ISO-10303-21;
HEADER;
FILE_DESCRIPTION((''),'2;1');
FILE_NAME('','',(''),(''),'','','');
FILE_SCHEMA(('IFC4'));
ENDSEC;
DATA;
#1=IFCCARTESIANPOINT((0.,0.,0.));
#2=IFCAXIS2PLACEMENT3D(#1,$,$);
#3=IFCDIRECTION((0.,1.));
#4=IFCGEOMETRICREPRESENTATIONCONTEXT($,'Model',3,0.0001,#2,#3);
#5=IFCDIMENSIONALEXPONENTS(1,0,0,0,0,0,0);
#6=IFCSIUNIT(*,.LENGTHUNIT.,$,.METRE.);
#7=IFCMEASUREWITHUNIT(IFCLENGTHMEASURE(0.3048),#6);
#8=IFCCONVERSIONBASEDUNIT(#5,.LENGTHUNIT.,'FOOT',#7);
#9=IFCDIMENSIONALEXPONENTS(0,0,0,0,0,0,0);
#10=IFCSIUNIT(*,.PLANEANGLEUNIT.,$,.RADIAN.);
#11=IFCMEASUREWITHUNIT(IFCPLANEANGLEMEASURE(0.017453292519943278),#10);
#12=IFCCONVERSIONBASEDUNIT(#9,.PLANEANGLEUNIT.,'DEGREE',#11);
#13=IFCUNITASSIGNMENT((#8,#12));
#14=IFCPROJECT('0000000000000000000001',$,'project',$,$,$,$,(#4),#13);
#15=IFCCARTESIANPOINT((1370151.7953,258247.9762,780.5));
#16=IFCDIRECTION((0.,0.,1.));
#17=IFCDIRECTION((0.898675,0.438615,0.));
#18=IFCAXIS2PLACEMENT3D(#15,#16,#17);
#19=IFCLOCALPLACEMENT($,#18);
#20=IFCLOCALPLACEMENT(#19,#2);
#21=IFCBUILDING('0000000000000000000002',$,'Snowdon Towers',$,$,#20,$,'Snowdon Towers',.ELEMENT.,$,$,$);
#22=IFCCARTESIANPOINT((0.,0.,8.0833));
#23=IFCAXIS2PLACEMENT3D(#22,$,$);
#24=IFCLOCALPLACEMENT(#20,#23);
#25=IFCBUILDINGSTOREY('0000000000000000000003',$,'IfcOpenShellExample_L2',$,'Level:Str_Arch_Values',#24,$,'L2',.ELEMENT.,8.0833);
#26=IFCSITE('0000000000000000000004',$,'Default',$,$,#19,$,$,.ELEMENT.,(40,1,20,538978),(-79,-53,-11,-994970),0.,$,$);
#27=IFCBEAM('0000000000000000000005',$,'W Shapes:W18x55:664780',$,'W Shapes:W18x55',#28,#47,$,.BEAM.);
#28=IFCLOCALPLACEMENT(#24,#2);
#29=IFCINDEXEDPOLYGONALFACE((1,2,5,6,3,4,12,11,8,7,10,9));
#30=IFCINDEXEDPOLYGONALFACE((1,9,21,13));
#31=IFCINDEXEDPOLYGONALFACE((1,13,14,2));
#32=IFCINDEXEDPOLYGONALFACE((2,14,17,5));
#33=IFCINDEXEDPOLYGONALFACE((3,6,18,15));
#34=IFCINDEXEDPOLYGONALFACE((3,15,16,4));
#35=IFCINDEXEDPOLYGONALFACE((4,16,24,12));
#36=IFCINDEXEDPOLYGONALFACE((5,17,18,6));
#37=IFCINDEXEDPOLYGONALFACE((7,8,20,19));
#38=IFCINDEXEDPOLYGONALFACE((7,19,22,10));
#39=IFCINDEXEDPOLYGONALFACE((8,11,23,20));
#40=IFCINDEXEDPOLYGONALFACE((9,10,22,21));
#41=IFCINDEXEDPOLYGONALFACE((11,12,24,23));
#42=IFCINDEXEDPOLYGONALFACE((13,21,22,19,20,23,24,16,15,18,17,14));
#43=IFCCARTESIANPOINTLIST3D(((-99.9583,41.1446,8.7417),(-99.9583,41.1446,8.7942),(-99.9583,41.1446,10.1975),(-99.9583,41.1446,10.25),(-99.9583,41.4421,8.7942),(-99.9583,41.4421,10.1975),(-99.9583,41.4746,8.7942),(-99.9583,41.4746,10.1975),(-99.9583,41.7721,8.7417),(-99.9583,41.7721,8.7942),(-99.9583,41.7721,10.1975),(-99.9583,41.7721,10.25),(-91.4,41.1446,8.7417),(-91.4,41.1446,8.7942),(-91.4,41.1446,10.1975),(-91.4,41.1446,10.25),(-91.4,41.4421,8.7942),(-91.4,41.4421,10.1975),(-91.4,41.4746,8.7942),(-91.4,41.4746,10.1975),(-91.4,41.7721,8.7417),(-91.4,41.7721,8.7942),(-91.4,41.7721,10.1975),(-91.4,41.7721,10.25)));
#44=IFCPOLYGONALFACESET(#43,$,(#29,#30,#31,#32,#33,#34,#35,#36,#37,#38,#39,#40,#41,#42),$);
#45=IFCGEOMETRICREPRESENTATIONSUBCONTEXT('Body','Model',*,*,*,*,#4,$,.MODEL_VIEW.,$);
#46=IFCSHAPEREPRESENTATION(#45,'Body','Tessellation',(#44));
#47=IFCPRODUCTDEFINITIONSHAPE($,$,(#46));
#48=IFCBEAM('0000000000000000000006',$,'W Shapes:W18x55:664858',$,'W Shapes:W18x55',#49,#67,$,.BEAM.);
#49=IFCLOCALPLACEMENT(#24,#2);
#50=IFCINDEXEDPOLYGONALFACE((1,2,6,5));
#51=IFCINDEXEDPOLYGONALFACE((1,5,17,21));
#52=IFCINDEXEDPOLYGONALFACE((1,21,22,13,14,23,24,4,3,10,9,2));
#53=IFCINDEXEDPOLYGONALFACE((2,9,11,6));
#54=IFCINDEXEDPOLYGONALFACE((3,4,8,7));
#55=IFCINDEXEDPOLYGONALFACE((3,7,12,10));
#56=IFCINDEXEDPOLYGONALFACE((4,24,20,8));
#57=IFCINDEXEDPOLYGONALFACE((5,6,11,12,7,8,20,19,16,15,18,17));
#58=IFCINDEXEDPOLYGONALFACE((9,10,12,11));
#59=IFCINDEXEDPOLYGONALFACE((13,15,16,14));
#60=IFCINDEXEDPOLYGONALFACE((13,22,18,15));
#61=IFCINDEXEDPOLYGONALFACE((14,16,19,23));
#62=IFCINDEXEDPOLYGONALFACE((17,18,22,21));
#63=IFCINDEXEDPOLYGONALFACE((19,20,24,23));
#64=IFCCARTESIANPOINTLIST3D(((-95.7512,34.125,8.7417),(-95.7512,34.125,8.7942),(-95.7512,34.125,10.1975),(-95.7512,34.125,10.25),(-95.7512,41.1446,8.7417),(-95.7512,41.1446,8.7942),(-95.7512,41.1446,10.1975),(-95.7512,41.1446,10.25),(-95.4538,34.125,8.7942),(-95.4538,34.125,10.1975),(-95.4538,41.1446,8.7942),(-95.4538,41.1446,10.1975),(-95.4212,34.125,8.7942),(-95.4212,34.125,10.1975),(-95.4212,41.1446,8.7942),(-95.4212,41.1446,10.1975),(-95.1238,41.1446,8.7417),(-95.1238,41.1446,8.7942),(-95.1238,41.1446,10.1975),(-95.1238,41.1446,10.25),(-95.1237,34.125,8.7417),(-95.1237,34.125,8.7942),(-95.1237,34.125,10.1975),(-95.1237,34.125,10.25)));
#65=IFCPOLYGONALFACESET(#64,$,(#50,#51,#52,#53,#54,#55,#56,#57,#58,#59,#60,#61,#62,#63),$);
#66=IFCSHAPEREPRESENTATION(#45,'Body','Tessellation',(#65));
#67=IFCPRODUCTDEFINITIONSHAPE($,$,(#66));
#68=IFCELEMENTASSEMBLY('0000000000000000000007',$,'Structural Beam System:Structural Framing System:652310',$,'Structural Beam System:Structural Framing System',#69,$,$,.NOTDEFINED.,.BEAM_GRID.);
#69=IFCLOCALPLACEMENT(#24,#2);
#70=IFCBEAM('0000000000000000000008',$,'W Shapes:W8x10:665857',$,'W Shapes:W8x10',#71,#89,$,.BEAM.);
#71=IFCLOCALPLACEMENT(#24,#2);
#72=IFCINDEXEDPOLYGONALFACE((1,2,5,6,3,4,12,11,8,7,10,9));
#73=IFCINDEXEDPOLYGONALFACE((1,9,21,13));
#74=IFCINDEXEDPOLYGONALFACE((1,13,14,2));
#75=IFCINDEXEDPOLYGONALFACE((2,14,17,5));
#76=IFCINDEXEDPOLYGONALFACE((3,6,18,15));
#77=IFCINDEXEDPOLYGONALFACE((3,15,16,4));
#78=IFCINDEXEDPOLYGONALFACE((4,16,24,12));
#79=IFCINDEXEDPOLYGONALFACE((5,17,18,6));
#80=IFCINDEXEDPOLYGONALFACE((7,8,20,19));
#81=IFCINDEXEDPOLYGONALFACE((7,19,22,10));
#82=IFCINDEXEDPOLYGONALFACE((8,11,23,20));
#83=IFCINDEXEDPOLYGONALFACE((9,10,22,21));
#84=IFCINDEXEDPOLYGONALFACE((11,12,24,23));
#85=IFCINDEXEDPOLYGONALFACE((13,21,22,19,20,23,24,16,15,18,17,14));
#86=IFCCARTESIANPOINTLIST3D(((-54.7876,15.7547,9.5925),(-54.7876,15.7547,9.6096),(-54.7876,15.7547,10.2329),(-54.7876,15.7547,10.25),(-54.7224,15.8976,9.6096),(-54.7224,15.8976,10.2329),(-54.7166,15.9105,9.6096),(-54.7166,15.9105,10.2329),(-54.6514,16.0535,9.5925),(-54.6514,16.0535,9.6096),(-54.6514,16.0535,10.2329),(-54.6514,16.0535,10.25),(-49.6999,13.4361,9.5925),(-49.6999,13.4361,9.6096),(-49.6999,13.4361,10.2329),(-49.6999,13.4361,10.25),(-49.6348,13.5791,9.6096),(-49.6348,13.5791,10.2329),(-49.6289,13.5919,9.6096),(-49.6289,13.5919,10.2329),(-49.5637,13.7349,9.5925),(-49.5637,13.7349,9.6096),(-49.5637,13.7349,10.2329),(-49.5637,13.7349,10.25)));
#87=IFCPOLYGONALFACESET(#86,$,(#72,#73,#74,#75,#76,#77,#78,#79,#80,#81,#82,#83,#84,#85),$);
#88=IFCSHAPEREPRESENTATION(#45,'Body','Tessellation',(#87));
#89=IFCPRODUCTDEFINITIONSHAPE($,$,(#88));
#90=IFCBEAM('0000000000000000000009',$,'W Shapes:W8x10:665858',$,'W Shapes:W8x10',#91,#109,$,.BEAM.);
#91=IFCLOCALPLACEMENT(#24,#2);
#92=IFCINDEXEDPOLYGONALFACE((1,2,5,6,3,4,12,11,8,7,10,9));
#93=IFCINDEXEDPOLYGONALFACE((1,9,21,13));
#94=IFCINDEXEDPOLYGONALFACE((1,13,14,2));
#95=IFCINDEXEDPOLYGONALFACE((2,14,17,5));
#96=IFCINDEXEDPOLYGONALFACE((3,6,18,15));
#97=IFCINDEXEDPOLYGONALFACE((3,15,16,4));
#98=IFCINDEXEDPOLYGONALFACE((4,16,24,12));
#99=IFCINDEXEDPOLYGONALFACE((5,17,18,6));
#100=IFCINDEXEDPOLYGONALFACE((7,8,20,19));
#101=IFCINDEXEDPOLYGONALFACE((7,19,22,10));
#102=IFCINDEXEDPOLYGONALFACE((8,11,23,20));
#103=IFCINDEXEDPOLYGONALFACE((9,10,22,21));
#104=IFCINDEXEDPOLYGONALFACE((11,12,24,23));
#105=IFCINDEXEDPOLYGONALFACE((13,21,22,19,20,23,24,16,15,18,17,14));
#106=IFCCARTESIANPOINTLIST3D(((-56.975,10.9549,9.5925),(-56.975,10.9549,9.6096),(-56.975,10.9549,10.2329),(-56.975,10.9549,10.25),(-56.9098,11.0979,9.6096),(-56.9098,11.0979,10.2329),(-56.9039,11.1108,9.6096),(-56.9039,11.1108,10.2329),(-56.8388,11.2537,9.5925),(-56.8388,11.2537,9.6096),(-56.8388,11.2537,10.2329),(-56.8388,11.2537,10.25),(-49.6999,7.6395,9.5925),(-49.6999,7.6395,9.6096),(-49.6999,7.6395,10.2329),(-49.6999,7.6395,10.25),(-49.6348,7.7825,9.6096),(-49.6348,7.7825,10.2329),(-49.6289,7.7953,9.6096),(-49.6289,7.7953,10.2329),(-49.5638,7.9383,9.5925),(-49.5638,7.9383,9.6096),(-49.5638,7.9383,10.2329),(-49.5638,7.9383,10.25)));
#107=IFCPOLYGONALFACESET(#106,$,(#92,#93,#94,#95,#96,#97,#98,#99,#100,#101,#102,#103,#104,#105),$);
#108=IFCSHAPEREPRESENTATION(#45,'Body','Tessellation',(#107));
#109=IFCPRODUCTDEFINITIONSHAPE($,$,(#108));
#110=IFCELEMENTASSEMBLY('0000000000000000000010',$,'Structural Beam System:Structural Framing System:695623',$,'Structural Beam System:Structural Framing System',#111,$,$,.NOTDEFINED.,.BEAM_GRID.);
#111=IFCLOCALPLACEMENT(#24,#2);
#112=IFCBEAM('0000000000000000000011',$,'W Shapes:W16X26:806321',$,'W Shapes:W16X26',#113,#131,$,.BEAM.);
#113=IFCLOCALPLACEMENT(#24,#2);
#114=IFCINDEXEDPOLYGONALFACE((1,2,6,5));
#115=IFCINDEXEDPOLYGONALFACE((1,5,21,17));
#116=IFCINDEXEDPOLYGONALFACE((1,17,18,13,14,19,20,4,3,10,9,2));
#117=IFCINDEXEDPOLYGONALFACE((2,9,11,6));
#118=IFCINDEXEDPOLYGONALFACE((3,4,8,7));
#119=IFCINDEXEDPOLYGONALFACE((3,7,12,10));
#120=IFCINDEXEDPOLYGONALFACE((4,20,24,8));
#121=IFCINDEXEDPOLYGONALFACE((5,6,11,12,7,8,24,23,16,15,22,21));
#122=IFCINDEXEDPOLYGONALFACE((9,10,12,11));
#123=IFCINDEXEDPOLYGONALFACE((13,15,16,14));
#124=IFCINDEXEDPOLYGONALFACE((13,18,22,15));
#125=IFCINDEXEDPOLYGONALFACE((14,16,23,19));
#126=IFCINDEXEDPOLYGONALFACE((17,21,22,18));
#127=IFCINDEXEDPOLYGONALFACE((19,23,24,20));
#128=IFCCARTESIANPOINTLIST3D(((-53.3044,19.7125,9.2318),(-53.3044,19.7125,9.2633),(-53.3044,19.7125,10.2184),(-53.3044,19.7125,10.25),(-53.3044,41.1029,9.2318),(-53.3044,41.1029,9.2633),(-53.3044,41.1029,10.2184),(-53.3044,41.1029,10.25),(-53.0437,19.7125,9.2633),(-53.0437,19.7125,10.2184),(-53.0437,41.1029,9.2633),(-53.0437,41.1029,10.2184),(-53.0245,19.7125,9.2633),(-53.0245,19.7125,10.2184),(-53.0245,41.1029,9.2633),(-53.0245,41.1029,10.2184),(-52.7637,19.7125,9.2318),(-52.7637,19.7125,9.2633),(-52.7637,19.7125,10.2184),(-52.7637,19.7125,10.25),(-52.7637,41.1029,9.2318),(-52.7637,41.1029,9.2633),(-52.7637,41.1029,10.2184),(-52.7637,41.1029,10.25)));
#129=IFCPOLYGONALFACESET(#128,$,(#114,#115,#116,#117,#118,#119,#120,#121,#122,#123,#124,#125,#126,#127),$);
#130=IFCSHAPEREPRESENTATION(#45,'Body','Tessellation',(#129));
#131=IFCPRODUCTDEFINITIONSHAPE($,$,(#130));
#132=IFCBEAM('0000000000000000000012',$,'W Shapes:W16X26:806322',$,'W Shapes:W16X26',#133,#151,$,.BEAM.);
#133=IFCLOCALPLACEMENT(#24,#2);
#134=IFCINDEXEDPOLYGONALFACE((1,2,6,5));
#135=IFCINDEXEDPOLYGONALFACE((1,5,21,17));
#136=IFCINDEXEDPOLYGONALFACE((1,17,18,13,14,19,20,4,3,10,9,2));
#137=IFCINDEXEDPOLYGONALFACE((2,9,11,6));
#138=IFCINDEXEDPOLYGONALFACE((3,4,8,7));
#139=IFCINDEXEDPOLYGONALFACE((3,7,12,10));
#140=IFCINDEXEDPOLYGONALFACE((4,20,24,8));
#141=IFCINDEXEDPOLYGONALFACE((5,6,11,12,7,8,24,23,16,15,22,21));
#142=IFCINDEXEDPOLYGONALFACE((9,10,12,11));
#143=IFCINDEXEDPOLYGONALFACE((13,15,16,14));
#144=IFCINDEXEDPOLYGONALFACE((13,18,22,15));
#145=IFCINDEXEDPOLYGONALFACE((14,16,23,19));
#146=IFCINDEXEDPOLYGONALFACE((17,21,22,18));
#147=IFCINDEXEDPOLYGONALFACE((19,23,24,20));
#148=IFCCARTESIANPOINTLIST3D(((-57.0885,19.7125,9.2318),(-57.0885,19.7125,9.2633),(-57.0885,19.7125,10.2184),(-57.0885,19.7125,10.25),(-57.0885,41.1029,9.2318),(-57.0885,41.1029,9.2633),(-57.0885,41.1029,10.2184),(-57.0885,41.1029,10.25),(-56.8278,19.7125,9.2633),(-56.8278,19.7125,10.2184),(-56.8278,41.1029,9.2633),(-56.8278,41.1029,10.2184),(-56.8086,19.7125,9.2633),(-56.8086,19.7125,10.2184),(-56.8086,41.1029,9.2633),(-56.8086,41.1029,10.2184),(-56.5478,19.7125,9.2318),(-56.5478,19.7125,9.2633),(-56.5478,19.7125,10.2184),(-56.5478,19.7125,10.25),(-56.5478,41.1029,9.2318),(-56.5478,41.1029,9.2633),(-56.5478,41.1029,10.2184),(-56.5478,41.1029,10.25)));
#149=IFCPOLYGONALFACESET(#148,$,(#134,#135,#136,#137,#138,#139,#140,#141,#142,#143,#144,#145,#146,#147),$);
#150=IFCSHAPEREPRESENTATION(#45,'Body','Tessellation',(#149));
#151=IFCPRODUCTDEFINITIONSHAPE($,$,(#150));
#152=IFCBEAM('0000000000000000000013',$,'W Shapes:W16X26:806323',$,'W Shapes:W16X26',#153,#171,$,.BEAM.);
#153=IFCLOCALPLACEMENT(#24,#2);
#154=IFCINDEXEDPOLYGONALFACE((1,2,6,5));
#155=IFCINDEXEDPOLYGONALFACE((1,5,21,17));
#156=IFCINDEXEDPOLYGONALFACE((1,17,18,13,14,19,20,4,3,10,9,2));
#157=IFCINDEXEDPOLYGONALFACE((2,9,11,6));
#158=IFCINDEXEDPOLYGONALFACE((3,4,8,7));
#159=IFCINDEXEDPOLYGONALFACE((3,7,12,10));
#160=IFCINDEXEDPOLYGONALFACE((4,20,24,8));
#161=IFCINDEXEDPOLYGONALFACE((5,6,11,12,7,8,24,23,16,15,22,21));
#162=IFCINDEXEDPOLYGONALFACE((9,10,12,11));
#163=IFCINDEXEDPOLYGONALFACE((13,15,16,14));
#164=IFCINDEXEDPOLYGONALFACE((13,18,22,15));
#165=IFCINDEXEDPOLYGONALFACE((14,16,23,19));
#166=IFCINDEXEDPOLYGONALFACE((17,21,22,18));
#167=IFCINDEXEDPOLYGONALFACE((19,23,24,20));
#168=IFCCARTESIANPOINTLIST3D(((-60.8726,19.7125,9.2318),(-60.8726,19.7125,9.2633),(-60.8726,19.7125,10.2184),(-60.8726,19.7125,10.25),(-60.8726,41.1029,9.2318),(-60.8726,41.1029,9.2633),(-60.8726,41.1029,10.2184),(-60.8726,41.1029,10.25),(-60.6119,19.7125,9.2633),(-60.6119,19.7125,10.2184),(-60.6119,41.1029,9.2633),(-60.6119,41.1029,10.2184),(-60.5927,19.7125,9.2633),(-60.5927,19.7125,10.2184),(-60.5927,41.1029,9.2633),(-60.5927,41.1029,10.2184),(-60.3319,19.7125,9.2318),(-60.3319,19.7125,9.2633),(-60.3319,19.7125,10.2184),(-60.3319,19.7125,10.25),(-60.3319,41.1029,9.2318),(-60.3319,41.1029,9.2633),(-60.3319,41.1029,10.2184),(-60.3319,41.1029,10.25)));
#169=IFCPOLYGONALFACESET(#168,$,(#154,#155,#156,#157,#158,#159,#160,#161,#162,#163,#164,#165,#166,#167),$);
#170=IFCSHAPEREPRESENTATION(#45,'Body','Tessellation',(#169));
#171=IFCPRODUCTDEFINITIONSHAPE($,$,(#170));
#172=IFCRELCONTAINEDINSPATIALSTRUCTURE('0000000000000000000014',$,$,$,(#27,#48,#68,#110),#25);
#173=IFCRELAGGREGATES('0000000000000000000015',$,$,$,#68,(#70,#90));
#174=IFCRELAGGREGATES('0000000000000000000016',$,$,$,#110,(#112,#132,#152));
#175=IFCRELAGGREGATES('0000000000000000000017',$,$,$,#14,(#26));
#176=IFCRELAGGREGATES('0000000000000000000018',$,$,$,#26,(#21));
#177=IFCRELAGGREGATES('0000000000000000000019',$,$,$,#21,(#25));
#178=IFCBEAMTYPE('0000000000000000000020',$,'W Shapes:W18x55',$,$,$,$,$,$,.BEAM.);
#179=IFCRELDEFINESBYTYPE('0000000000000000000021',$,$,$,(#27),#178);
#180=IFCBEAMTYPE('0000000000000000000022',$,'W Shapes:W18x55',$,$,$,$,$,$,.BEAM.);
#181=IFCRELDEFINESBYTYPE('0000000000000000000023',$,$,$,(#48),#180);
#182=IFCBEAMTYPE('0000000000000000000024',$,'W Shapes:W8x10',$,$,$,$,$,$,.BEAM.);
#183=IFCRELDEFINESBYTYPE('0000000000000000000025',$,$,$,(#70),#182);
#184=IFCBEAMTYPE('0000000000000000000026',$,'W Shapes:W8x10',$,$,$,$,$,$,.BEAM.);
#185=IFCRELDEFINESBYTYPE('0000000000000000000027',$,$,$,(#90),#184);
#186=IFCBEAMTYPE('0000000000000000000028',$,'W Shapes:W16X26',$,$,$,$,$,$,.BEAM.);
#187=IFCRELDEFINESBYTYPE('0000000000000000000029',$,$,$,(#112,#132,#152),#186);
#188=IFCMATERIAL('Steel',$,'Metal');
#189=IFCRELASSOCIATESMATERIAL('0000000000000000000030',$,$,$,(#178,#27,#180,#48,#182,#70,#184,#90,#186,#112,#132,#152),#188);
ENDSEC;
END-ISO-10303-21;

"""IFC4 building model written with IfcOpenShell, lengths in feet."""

from ifc_helpers import new_model, entity, si_unit, converted_unit, direction, frame, origin, place, context, subcontext, project, spatial, indexed_curve, outline, extrude, source, transform, mapped, material, type_object, type_shapes, element, aggregate, save


model = new_model("IFC4")

# Units and contexts
model_context = context("Model", 3, precision=0.0001, world=origin(), true_north=direction((0.0, 1.0)))
body_context = subcontext(model_context, "Body", "Model", "MODEL_VIEW")
ifc_project = project(units=[converted_unit("LENGTHUNIT", "FOOT", entity("IfcLengthMeasure", 0.3048), si_unit("LENGTHUNIT", "METRE"), dimensions=[1, 0, 0, 0, 0, 0, 0]), converted_unit("PLANEANGLEUNIT", "DEGREE", entity("IfcPlaneAngleMeasure", 0.017453292519943278), si_unit("PLANEANGLEUNIT", "RADIAN"), dimensions=[0, 0, 0, 0, 0, 0, 0])], contexts=[model_context])

# Site, building, storey
site_placement = place(None, frame((1370151.7953, 258247.9762, 780.5), z_axis=(0.0, 0.0, 1.0), x_axis=(0.898675, 0.438615, 0.0)))
site = spatial("IfcSite", under=ifc_project, at=site_placement, Name="Default", CompositionType="ELEMENT", RefLatitude=(40, 1, 20, 538978), RefLongitude=(-79, -53, -11, -994970), RefElevation=0.0)
building_placement = place(site_placement, origin())
building = spatial("IfcBuilding", under=site, at=building_placement, Name="Snowdon Towers", LongName="Snowdon Towers", CompositionType="ELEMENT")
storey_placement = place(building_placement, frame((0.0, 0.0, 8.0833)))
storey = spatial("IfcBuildingStorey", under=building, at=storey_placement, Name="IfcOpenShellExample_L2", ObjectType="Level:Str_Arch_Values", LongName="L2", CompositionType="ELEMENT", Elevation=8.0833)

# Shared definitions
ifc_material = material(Name="Steel", Category="Metal")

# Beams
beam_type_1 = type_object("IfcBeamType", Name="W Shapes:W18x55", PredefinedType="BEAM", material=ifc_material)
shared_shape_1 = source(origin(), body_context, "Body", "SweptSolid", [
    extrude(outline(indexed_curve([(-0.3138, -0.7017), (-0.3138, -0.7542), (0.3138, -0.7542), (0.3138, -0.7017), (0.0162, -0.7017), (0.0162, 0.7017), (0.3138, 0.7017), (0.3138, 0.7542), (-0.3137, 0.7542), (-0.3137, 0.7017), (-0.0163, 0.7017), (-0.0163, -0.7017), (-0.3138, -0.7017)], self_intersect=False)), frame((-4.6042, 0.0, 0.0), z_axis=(-1.0, 0.0, 0.0), x_axis=(0.0, -1.0, 0.0)), (0.0, 0.0, -1.0), 8.5583),
])
type_shapes(beam_type_1, [shared_shape_1])
beam_1_placement = place(storey_placement, frame((-95.3542, 41.4583, 9.4958)))
element("IfcBeam", 1, at=beam_1_placement, inside=storey, type_object=beam_type_1, material=ifc_material, Name="W Shapes:W18x55:664780", ObjectType="W Shapes:W18x55", PredefinedType="BEAM", context=body_context, shape_type="MappedRepresentation", body=[
    mapped(shared_shape_1, transform((0.0, 0.0, 0.0), scale=1.0)),
])
beam_type_2 = type_object("IfcBeamType", Name="W Shapes:W18x55", PredefinedType="BEAM", material=ifc_material)
shared_shape_2 = source(origin(), body_context, "Body", "SweptSolid", [
    extrude(outline(indexed_curve([(-0.3138, -0.7017), (-0.3138, -0.7542), (0.3138, -0.7542), (0.3138, -0.7017), (0.0162, -0.7017), (0.0162, 0.7017), (0.3138, 0.7017), (0.3138, 0.7542), (-0.3137, 0.7542), (-0.3137, 0.7017), (-0.0163, 0.7017), (-0.0163, -0.7017), (-0.3138, -0.7017)], self_intersect=False)), frame((-3.3529, 0.0, 0.0), z_axis=(-1.0, 0.0, 0.0), x_axis=(0.0, -1.0, 0.0)), (0.0, 0.0, -1.0), 7.0196),
])
type_shapes(beam_type_2, [shared_shape_2])
beam_2_placement = place(storey_placement, frame((-95.4375, 37.7917, 9.4958), z_axis=(0.0, 0.0, 1.0), x_axis=(0.0, -1.0, 0.0)))
element("IfcBeam", 2, at=beam_2_placement, inside=storey, type_object=beam_type_2, material=ifc_material, Name="W Shapes:W18x55:664858", ObjectType="W Shapes:W18x55", PredefinedType="BEAM", context=body_context, shape_type="MappedRepresentation", body=[
    mapped(shared_shape_2, transform((0.0, 0.0, 0.0), scale=1.0)),
])

# Element assembly, beams
assembly_1_placement = place(storey_placement, origin())
assembly_1 = element("IfcElementAssembly", 3, at=assembly_1_placement, inside=storey, Name="Structural Beam System:Structural Framing System:652310", ObjectType="Structural Beam System:Structural Framing System", AssemblyPlace="NOTDEFINED", PredefinedType="BEAM_GRID")
beam_type_3 = type_object("IfcBeamType", Name="W Shapes:W8x10", PredefinedType="BEAM", material=ifc_material)
shared_shape_3 = source(origin(), body_context, "Body", "SweptSolid", [
    extrude(outline(indexed_curve([(-0.1642, -0.3117), (-0.1642, -0.3288), (0.1642, -0.3288), (0.1642, -0.3117), (0.0071, -0.3117), (0.0071, 0.3117), (0.1642, 0.3117), (0.1642, 0.3287), (-0.1642, 0.3287), (-0.1642, 0.3117), (-0.0071, 0.3117), (-0.0071, -0.3117), (-0.1642, -0.3117)], self_intersect=False)), frame((-2.7741, 0.0, 0.0), z_axis=(-1.0, 0.0, 0.0), x_axis=(0.0, -1.0, 0.0)), (0.0, 0.0, -1.0), 5.5911),
])
type_shapes(beam_type_3, [shared_shape_3])
beam_3_placement = place(assembly_1_placement, frame((-52.1952, 14.7537, 9.9213), z_axis=(0.0, 0.0, 1.0), x_axis=(0.909961, -0.414693, 0.0)))
beam_3 = element("IfcBeam", 4, at=beam_3_placement, type_object=beam_type_3, material=ifc_material, Name="W Shapes:W8x10:665857", ObjectType="W Shapes:W8x10", PredefinedType="BEAM", context=body_context, shape_type="MappedRepresentation", body=[
    mapped(shared_shape_3, transform((0.0, 0.0, 0.0), scale=1.0)),
])
beam_type_4 = type_object("IfcBeamType", Name="W Shapes:W8x10", PredefinedType="BEAM", material=ifc_material)
shared_shape_4 = source(origin(), body_context, "Body", "SweptSolid", [
    extrude(outline(indexed_curve([(-0.1642, -0.3117), (-0.1642, -0.3288), (0.1642, -0.3288), (0.1642, -0.3117), (0.0071, -0.3117), (0.0071, 0.3117), (0.1642, 0.3117), (0.1642, 0.3287), (-0.1642, 0.3287), (-0.1642, 0.3117), (-0.0071, 0.3117), (-0.0071, -0.3117), (-0.1642, -0.3117)], self_intersect=False)), frame((-3.976, 0.0, 0.0), z_axis=(-1.0, 0.0, 0.0), x_axis=(0.0, -1.0, 0.0)), (0.0, 0.0, -1.0), 7.9949),
])
type_shapes(beam_type_4, [shared_shape_4])
beam_4_placement = place(assembly_1_placement, frame((-53.2889, 9.4555, 9.9213), z_axis=(0.0, 0.0, 1.0), x_axis=(0.909961, -0.414693, 0.0)))
beam_4 = element("IfcBeam", 5, at=beam_4_placement, type_object=beam_type_4, material=ifc_material, Name="W Shapes:W8x10:665858", ObjectType="W Shapes:W8x10", PredefinedType="BEAM", context=body_context, shape_type="MappedRepresentation", body=[
    mapped(shared_shape_4, transform((0.0, 0.0, 0.0), scale=1.0)),
])
aggregate(assembly_1, [beam_3, beam_4])

# Element assembly, beams
assembly_2_placement = place(storey_placement, origin())
assembly_2 = element("IfcElementAssembly", 6, at=assembly_2_placement, inside=storey, Name="Structural Beam System:Structural Framing System:695623", ObjectType="Structural Beam System:Structural Framing System", AssemblyPlace="NOTDEFINED", PredefinedType="BEAM_GRID")
beam_type_5 = type_object("IfcBeamType", Name="W Shapes:W16X26", PredefinedType="BEAM", material=ifc_material)
shared_shape_5 = source(origin(), body_context, "Body", "SweptSolid", [
    extrude(outline(indexed_curve([(-0.2703, -0.4775), (-0.2703, -0.5091), (0.2703, -0.5091), (0.2703, -0.4775), (0.0096, -0.4775), (0.0096, 0.4775), (0.2703, 0.4775), (0.2703, 0.5091), (-0.2703, 0.5091), (-0.2703, 0.4775), (-0.0096, 0.4775), (-0.0096, -0.4775), (-0.2703, -0.4775)], self_intersect=False)), frame((-10.7696, 0.0, 0.0), z_axis=(-1.0, 0.0, 0.0), x_axis=(0.0, -1.0, 0.0)), (0.0, 0.0, -1.0), 21.3904),
])
type_shapes(beam_type_5, [shared_shape_5])
beam_5_placement = place(assembly_2_placement, frame((-53.0341, 30.3333, 9.7409), z_axis=(0.0, 0.0, 1.0), x_axis=(0.0, -1.0, 0.0)))
beam_5 = element("IfcBeam", 7, at=beam_5_placement, type_object=beam_type_5, material=ifc_material, Name="W Shapes:W16X26:806321", ObjectType="W Shapes:W16X26", PredefinedType="BEAM", context=body_context, shape_type="MappedRepresentation", body=[
    mapped(shared_shape_5, transform((0.0, 0.0, 0.0), scale=1.0)),
])
beam_6_placement = place(assembly_2_placement, frame((-56.8182, 30.3333, 9.7409), z_axis=(0.0, 0.0, 1.0), x_axis=(0.0, -1.0, 0.0)))
beam_6 = element("IfcBeam", 8, at=beam_6_placement, type_object=beam_type_5, material=ifc_material, Name="W Shapes:W16X26:806322", ObjectType="W Shapes:W16X26", PredefinedType="BEAM", context=body_context, shape_type="MappedRepresentation", body=[
    mapped(shared_shape_5, transform((0.0, 0.0, 0.0), scale=1.0)),
])
beam_7_placement = place(assembly_2_placement, frame((-60.6023, 30.3333, 9.7409), z_axis=(0.0, 0.0, 1.0), x_axis=(0.0, -1.0, 0.0)))
beam_7 = element("IfcBeam", 9, at=beam_7_placement, type_object=beam_type_5, material=ifc_material, Name="W Shapes:W16X26:806323", ObjectType="W Shapes:W16X26", PredefinedType="BEAM", context=body_context, shape_type="MappedRepresentation", body=[
    mapped(shared_shape_5, transform((0.0, 0.0, 0.0), scale=1.0)),
])
aggregate(assembly_2, [beam_5, beam_6, beam_7])

save(model, "model.ifc")
